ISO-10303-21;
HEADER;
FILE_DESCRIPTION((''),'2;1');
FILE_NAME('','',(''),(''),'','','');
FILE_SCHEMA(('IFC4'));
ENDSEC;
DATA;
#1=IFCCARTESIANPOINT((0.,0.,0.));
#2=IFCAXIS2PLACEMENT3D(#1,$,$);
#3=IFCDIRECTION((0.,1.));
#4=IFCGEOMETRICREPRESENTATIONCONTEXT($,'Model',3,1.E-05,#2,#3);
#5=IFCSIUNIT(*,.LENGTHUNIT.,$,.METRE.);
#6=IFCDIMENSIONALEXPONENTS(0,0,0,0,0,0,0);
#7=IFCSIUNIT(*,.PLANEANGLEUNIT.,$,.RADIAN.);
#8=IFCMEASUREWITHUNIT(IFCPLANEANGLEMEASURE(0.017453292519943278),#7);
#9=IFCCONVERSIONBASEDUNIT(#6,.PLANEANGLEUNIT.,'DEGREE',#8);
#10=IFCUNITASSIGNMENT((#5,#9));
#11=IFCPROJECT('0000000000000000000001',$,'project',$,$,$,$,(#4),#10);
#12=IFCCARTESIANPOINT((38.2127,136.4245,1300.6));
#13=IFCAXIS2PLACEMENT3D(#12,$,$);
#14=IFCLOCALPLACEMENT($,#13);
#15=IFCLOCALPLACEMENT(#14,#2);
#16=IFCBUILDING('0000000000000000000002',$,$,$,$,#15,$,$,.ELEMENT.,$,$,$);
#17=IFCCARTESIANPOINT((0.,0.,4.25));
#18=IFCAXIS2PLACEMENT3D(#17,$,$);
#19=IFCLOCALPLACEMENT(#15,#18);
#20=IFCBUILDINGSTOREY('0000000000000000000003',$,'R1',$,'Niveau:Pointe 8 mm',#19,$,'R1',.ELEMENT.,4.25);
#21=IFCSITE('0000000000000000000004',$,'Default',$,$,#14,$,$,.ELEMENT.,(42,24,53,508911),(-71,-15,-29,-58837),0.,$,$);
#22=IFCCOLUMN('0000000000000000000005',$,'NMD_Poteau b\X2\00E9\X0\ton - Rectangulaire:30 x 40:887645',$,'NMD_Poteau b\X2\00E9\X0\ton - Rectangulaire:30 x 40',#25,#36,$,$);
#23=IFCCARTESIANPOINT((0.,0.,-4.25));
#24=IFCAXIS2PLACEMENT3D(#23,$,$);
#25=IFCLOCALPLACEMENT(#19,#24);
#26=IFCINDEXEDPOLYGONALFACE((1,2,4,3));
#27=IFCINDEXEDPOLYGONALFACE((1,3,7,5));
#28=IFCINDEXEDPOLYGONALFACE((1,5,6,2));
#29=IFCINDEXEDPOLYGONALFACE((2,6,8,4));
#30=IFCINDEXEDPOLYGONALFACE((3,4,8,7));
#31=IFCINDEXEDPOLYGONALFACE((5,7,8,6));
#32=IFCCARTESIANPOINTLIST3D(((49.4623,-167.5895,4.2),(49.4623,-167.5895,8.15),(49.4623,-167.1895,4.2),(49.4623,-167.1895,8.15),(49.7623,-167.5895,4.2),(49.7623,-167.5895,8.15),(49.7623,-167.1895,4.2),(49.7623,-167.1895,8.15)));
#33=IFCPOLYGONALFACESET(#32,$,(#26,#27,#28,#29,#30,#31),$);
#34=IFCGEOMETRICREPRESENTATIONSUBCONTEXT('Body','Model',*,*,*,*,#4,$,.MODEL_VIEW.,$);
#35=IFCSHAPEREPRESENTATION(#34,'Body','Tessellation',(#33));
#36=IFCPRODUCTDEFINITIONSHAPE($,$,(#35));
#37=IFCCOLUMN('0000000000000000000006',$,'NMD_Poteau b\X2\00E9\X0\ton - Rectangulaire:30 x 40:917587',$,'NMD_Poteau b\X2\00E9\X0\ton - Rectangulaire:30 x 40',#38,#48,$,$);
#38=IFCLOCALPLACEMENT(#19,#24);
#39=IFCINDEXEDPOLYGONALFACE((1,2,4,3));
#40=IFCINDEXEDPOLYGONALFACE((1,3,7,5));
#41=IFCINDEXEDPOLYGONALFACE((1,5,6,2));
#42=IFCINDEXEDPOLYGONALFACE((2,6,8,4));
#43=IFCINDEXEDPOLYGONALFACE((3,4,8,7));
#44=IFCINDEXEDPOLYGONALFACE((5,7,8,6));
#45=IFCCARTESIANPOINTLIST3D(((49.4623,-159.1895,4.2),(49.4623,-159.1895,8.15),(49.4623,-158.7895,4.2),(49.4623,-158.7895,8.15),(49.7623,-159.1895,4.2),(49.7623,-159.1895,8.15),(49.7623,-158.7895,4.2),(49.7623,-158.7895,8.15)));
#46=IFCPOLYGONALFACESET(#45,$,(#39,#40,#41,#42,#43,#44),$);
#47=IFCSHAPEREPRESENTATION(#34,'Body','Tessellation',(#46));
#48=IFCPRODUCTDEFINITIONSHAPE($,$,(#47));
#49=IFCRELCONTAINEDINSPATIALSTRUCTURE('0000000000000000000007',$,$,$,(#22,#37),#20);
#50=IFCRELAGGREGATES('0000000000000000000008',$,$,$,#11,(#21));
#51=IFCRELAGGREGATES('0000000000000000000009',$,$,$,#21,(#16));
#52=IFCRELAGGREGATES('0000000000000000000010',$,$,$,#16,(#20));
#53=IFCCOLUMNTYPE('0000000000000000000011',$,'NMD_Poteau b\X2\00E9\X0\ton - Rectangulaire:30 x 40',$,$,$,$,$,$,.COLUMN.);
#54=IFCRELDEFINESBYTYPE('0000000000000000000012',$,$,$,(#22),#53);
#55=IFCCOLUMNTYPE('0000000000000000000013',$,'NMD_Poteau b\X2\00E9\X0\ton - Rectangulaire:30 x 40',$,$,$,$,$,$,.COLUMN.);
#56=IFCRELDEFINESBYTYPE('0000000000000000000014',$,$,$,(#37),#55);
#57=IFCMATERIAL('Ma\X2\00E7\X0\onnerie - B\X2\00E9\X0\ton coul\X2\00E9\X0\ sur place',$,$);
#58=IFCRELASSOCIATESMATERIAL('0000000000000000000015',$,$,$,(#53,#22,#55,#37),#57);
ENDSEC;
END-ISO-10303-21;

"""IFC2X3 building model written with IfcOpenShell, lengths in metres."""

from ifc_helpers import new_model, entity, si_unit, converted_unit, direction, frame, frame_2d, origin, place, context, subcontext, project, spatial, rectangle, extrude, source, transform, mapped, material, type_object, type_shapes, element, save


model = new_model("IFC2X3")

# Units and contexts
model_context = context("Model", 3, precision=1e-05, world=origin(), true_north=direction((0.0, 1.0)))
body_context = subcontext(model_context, "Body", "Model", "MODEL_VIEW")
ifc_project = project(units=[si_unit("LENGTHUNIT", "METRE"), converted_unit("PLANEANGLEUNIT", "DEGREE", entity("IfcPlaneAngleMeasure", 0.017453292519943278), si_unit("PLANEANGLEUNIT", "RADIAN"), dimensions=[0, 0, 0, 0, 0, 0, 0])], contexts=[model_context])

# Site, building, storey
site_placement = place(None, frame((38.2127, 136.4245, 1300.6)))
site = spatial("IfcSite", under=ifc_project, at=site_placement, Name="Default", CompositionType="ELEMENT", RefLatitude=(42, 24, 53, 508911), RefLongitude=(-71, -15, -29, -58837), RefElevation=0.0)
building_placement = place(site_placement, origin())
building = spatial("IfcBuilding", under=site, at=building_placement, CompositionType="ELEMENT")
storey_placement = place(building_placement, frame((0.0, 0.0, 4.25)))
storey = spatial("IfcBuildingStorey", under=building, at=storey_placement, Name="R1", ObjectType="Niveau:Pointe 8 mm", LongName="R1", CompositionType="ELEMENT", Elevation=4.25)

# Columns
ifc_material = material(Name="Maçonnerie - Béton coulé sur place")
column_type_1 = type_object("IfcColumnType", Name="NMD_Poteau béton - Rectangulaire:30 x 40", PredefinedType="COLUMN", material=ifc_material)
shared_shape_1 = source(origin(), body_context, "Body", "SweptSolid", [
    extrude(rectangle(XDim=0.3, YDim=0.4, at=frame_2d((0.0, 0.0), x_axis=(1.0, 0.0))), frame((49.6123, -167.3895, 4.2), z_axis=(0.0, 0.0, 1.0), x_axis=(-1.0, 0.0, 0.0)), (0.0, 0.0, 1.0), 3.95),
])
type_shapes(column_type_1, [shared_shape_1])
column_1_placement = place(storey_placement, frame((0.0, 0.0, -4.25)))
element("IfcColumn", 1, at=column_1_placement, inside=storey, type_object=column_type_1, material=ifc_material, Name="NMD_Poteau béton - Rectangulaire:30 x 40:887645", ObjectType="NMD_Poteau béton - Rectangulaire:30 x 40", context=body_context, shape_type="MappedRepresentation", body=[
    mapped(shared_shape_1, transform((0.0, 0.0, 0.0), scale=1.0)),
])
column_type_2 = type_object("IfcColumnType", Name="NMD_Poteau béton - Rectangulaire:30 x 40", PredefinedType="COLUMN", material=ifc_material)
shared_shape_2 = source(origin(), body_context, "Body", "SweptSolid", [
    extrude(rectangle(XDim=0.3, YDim=0.4, at=frame_2d((0.0, 0.0), x_axis=(1.0, 0.0))), frame((49.6123, -158.9895, 4.2)), (0.0, 0.0, 1.0), 3.95),
])
type_shapes(column_type_2, [shared_shape_2])
column_2_placement = place(storey_placement, frame((0.0, 0.0, -4.25)))
element("IfcColumn", 2, at=column_2_placement, inside=storey, type_object=column_type_2, material=ifc_material, Name="NMD_Poteau béton - Rectangulaire:30 x 40:917587", ObjectType="NMD_Poteau béton - Rectangulaire:30 x 40", context=body_context, shape_type="MappedRepresentation", body=[
    mapped(shared_shape_2, transform((0.0, 0.0, 0.0), scale=1.0)),
])

save(model, "model.ifc")
